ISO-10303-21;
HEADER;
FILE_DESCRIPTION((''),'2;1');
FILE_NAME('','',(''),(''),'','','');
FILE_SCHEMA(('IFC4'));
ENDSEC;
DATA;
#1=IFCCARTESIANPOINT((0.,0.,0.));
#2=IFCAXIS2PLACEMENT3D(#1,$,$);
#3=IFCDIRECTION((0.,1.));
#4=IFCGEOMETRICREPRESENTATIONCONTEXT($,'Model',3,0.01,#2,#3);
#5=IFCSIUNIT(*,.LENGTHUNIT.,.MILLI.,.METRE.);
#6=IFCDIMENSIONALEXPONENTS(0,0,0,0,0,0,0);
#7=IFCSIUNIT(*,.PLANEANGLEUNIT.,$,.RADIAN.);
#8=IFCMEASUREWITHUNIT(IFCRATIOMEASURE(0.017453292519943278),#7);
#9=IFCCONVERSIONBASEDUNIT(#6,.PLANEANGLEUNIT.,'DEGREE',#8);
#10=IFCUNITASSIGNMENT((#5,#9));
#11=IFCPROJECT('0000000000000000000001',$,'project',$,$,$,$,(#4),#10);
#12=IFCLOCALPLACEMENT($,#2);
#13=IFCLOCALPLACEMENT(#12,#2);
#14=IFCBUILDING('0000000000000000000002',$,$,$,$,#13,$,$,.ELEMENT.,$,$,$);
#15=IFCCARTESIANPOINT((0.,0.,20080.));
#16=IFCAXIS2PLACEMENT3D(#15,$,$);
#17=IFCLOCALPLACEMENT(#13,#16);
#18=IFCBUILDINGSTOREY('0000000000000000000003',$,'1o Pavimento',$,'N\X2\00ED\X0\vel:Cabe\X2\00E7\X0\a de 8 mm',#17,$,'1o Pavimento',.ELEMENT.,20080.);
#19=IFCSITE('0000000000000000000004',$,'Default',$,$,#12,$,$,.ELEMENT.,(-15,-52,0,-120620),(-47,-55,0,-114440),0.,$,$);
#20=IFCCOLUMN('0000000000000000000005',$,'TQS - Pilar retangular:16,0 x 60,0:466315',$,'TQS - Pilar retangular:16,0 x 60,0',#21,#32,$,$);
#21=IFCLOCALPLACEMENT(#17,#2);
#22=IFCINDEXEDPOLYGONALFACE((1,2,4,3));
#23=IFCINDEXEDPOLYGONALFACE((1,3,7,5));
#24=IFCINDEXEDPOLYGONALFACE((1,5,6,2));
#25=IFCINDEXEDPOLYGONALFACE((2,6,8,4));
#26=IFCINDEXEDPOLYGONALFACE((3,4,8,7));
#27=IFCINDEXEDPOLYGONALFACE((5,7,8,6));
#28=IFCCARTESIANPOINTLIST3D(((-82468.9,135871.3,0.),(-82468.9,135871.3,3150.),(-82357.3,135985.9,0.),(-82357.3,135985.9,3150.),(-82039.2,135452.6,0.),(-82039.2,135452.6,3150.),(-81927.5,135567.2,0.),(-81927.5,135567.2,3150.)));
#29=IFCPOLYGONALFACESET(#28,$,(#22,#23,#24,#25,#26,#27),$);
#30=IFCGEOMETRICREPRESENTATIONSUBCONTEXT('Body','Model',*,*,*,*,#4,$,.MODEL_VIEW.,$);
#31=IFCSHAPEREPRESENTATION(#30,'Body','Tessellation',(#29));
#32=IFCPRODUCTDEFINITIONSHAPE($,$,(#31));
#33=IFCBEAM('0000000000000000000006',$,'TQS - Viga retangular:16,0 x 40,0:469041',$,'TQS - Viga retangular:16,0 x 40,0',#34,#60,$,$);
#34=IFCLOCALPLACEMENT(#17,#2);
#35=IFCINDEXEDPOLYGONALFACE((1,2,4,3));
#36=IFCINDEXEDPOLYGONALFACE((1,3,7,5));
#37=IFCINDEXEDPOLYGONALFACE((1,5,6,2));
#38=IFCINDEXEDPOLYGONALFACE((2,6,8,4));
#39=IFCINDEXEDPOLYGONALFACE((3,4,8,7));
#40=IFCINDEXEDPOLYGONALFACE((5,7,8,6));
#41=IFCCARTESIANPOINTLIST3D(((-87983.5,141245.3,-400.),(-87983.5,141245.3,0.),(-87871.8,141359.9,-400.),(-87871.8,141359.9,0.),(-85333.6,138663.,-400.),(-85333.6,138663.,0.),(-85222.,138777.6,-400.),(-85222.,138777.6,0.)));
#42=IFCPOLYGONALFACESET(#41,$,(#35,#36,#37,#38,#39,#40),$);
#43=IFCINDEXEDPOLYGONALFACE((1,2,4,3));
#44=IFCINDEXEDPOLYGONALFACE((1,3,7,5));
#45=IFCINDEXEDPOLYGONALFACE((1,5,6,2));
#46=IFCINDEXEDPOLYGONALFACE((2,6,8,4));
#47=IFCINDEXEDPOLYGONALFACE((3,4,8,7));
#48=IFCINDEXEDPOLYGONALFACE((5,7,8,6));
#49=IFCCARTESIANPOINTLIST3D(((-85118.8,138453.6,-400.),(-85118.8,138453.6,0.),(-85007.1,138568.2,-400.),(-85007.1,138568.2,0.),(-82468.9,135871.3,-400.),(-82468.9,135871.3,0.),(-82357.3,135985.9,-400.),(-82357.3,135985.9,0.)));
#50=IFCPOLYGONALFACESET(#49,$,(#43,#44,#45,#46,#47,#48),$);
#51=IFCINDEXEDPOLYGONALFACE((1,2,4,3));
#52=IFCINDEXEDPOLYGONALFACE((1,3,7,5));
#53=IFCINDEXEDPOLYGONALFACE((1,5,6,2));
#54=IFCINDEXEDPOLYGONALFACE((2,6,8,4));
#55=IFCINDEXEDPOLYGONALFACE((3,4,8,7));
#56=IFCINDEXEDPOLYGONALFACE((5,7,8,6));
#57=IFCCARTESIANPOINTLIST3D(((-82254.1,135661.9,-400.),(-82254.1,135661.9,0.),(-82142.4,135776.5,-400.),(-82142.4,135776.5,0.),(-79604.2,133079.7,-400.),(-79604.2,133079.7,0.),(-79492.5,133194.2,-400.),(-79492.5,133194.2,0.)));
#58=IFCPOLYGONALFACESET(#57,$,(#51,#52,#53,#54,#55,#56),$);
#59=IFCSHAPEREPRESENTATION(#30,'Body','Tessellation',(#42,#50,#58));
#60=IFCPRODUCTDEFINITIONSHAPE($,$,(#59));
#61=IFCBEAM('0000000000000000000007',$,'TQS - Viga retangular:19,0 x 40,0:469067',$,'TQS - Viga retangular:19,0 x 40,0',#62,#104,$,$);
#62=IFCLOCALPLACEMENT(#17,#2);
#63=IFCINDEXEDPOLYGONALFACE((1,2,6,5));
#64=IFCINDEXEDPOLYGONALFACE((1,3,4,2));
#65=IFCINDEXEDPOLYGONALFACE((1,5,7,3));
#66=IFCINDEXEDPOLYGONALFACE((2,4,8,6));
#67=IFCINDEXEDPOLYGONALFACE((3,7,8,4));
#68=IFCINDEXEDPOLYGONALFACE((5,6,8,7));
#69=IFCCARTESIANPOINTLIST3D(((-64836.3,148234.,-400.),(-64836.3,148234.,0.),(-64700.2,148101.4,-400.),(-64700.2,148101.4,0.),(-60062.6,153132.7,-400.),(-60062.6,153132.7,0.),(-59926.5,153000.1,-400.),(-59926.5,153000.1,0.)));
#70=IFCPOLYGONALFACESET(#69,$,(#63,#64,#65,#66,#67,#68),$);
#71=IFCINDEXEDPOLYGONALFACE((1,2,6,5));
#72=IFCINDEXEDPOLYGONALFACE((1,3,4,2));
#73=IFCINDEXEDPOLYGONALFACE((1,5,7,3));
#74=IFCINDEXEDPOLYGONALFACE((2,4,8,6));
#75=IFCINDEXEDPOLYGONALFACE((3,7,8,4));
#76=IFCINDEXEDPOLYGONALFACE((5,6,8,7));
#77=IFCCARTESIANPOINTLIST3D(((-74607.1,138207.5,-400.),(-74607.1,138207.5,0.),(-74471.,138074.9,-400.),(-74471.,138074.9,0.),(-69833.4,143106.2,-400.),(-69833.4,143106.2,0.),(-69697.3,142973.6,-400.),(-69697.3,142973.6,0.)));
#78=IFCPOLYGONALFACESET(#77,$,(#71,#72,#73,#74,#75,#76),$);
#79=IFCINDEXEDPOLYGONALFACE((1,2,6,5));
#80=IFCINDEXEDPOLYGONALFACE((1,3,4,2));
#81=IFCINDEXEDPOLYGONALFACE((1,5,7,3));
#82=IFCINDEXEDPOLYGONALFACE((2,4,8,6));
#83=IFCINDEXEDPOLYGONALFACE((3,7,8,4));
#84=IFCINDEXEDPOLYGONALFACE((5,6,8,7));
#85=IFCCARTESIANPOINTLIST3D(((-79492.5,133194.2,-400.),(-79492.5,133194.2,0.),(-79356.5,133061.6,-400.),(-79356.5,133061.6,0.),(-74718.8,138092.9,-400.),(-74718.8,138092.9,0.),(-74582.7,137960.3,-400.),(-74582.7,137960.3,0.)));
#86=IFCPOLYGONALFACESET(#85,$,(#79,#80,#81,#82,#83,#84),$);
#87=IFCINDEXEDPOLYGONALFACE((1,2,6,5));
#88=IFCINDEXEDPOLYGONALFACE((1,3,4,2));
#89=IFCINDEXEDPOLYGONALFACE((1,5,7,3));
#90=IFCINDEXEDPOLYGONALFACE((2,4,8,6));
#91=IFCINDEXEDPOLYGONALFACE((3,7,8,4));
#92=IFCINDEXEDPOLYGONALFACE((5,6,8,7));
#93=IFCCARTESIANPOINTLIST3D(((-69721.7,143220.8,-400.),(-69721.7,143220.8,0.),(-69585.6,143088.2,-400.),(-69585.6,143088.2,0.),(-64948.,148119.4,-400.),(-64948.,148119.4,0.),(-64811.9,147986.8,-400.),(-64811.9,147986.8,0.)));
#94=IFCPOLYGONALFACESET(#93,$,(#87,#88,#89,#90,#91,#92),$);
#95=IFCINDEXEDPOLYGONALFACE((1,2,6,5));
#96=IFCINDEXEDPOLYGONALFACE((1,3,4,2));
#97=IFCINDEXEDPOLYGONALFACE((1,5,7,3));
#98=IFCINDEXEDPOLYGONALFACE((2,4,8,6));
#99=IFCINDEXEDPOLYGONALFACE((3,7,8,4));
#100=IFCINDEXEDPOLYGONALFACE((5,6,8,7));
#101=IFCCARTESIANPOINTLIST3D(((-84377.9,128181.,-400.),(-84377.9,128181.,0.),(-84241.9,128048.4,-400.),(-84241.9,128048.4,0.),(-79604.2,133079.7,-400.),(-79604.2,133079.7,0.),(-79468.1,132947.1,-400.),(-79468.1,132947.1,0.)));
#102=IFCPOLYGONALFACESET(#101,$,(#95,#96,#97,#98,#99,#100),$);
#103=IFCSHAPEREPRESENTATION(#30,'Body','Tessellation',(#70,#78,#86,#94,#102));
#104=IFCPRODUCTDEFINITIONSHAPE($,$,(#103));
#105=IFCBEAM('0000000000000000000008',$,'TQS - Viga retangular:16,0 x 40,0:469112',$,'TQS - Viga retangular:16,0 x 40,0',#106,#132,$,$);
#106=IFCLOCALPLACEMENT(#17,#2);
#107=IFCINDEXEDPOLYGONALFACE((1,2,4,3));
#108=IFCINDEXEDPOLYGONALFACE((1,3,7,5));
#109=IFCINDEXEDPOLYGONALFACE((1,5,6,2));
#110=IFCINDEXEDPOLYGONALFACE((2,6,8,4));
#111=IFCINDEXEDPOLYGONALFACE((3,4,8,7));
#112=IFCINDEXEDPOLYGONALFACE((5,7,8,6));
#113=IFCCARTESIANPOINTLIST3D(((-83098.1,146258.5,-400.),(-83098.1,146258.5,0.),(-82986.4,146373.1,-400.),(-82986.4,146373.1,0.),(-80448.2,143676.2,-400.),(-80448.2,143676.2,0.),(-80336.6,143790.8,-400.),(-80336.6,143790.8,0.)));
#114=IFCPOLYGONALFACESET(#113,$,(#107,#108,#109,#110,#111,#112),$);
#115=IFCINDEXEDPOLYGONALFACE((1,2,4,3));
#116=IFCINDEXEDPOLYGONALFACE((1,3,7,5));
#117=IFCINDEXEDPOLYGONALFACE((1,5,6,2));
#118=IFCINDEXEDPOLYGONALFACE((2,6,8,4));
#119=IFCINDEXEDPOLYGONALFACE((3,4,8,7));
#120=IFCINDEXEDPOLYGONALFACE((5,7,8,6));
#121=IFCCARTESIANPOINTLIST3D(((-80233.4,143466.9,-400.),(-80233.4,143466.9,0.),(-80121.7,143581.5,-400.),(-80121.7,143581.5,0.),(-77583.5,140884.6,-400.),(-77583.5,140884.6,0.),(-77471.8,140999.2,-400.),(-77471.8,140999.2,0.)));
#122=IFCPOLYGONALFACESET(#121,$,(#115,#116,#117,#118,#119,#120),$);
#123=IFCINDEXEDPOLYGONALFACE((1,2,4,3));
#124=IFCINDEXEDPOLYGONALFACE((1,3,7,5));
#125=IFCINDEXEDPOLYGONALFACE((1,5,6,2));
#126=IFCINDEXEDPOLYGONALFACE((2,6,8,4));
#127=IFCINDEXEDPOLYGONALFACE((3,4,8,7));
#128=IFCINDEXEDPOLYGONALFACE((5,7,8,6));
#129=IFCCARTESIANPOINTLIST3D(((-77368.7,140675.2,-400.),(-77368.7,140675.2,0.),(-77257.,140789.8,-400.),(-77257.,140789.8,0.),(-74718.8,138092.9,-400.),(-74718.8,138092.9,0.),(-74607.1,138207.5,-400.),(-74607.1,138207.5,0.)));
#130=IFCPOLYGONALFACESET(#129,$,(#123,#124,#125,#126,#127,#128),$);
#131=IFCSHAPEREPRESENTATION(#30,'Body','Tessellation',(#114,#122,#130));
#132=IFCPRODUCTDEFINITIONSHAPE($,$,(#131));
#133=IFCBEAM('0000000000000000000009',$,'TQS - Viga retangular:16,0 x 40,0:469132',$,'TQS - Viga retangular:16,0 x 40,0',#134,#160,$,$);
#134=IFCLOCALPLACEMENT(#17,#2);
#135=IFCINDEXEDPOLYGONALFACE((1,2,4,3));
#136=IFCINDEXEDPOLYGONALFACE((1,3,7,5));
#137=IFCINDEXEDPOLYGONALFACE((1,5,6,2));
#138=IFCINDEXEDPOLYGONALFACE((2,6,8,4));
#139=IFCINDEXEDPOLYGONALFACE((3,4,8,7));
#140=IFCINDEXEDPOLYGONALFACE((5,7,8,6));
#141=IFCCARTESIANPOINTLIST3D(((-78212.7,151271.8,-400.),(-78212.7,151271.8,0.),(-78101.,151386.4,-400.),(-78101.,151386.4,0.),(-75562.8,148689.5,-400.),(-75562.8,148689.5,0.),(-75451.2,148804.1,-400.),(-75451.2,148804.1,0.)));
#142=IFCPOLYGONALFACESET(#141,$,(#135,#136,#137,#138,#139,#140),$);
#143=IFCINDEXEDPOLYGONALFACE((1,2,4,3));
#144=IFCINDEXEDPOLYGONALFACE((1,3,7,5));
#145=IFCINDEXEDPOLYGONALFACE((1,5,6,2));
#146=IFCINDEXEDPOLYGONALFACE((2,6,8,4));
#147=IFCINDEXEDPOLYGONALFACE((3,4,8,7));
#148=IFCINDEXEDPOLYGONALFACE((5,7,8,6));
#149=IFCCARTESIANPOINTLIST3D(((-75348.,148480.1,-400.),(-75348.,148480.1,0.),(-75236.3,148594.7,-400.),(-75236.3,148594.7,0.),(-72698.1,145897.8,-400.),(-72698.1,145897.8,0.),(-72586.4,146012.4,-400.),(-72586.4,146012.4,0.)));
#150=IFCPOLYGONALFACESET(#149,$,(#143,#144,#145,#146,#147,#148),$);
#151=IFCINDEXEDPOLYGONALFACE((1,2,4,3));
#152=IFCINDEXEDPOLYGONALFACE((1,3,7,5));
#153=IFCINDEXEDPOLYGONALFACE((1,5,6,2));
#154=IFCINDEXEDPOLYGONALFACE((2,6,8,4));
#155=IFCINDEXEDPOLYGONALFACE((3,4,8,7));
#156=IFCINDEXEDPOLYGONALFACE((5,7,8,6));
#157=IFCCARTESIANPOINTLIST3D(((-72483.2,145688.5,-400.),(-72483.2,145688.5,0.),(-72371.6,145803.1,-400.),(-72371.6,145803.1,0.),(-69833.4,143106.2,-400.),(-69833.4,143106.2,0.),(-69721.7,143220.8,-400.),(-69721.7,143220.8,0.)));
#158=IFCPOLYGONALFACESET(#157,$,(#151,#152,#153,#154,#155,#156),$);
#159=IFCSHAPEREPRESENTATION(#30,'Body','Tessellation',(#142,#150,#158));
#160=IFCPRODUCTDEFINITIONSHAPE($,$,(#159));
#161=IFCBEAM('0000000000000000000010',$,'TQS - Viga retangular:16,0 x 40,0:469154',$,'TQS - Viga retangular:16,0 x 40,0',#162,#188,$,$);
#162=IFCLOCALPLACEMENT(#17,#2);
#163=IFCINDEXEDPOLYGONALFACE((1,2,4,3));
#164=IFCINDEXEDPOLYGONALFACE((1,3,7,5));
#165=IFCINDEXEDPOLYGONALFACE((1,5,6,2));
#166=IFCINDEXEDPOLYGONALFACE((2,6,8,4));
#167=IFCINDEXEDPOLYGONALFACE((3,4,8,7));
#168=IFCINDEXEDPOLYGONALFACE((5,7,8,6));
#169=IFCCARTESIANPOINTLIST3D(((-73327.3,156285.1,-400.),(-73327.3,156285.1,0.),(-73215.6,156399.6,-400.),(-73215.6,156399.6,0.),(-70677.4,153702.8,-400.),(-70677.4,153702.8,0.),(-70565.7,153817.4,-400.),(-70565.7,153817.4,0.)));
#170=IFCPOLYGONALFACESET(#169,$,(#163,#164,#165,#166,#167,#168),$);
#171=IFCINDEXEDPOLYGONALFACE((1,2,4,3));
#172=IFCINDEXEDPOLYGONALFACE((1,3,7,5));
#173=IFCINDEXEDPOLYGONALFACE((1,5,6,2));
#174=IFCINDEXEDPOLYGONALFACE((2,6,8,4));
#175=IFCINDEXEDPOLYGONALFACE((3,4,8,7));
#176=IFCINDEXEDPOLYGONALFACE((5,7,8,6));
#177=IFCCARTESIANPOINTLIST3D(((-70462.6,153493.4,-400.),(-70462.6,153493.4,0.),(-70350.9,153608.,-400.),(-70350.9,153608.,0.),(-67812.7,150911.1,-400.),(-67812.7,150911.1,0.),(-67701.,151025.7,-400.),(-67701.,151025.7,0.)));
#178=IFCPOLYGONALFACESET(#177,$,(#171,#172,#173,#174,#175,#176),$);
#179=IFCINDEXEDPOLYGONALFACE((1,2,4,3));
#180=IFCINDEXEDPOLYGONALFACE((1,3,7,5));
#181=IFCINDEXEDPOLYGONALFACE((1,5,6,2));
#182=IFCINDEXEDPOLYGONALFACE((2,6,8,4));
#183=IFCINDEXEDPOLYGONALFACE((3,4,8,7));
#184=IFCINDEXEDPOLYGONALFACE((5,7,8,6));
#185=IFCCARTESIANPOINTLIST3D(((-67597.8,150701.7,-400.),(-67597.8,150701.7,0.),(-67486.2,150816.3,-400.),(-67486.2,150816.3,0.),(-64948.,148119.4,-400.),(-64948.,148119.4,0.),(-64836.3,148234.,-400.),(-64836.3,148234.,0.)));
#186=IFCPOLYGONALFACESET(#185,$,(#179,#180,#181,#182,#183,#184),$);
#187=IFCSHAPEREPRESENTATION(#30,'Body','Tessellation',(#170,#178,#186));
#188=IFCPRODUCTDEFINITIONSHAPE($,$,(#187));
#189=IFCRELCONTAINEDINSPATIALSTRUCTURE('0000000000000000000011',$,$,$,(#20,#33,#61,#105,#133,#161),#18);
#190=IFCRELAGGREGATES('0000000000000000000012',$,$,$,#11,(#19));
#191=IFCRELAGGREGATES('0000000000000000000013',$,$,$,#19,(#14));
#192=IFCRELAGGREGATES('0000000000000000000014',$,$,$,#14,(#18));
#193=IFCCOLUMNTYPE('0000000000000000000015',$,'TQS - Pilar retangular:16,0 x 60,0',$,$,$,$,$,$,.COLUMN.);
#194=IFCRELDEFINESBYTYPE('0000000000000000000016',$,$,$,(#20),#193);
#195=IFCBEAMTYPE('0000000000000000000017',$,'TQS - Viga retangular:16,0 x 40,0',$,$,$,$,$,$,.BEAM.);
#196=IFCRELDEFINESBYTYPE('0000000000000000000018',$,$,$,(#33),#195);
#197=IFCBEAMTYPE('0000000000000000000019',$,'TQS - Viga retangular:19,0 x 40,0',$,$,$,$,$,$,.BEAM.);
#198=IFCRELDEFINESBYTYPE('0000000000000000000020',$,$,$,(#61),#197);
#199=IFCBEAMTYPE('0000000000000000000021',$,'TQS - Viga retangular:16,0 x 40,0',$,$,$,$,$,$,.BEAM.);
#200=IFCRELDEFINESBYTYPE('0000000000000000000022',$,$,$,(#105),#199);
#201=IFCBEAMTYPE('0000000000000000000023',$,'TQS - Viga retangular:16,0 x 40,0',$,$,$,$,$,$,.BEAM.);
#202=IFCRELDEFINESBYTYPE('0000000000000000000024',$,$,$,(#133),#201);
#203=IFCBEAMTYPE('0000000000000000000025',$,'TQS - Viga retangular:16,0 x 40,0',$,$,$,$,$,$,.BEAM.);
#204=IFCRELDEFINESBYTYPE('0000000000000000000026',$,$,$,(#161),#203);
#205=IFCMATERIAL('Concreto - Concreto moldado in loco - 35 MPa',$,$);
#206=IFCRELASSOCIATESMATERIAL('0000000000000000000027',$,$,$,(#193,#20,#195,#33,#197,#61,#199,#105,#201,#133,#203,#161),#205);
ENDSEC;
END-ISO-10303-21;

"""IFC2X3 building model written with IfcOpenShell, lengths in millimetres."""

from ifc_helpers import new_model, entity, si_unit, converted_unit, direction, frame, frame_2d, origin, place, context, subcontext, project, spatial, rectangle, extrude, source, transform, mapped, material, type_object, type_shapes, element, save


model = new_model("IFC2X3")

# Units and contexts
model_context = context("Model", 3, precision=0.01, world=origin(), true_north=direction((0.0, 1.0)))
body_context = subcontext(model_context, "Body", "Model", "MODEL_VIEW")
ifc_project = project(units=[si_unit("LENGTHUNIT", "METRE", prefix="MILLI"), converted_unit("PLANEANGLEUNIT", "DEGREE", entity("IfcRatioMeasure", 0.017453292519943278), si_unit("PLANEANGLEUNIT", "RADIAN"), dimensions=[0, 0, 0, 0, 0, 0, 0])], contexts=[model_context])

# Site, building, storey
site_placement = place(None, origin())
site = spatial("IfcSite", under=ifc_project, at=site_placement, Name="Default", CompositionType="ELEMENT", RefLatitude=(-15, -52, 0, -120620), RefLongitude=(-47, -55, 0, -114440), RefElevation=0.0)
building_placement = place(site_placement, origin())
building = spatial("IfcBuilding", under=site, at=building_placement, CompositionType="ELEMENT")
storey_placement = place(building_placement, frame((0.0, 0.0, 20080.0)))
storey = spatial("IfcBuildingStorey", under=building, at=storey_placement, Name="1o Pavimento", ObjectType="Nível:Cabeça de 8 mm", LongName="1o Pavimento", CompositionType="ELEMENT", Elevation=20080.0)

# Column
ifc_material = material(Name="Concreto - Concreto moldado in loco - 35 MPa")
column_type = type_object("IfcColumnType", Name="TQS - Pilar retangular:16,0 x 60,0", PredefinedType="COLUMN", material=ifc_material)
shared_shape_1 = source(origin(), body_context, "Body", "SweptSolid", [
    extrude(rectangle(XDim=600.0, YDim=160.0, at=frame_2d((0.0, 0.0), x_axis=(1.0, 0.0))), frame((-82198.2, 135719.2, 20080.0), z_axis=(0.0, 0.0, 1.0), x_axis=(-0.71618, 0.697915, 0.0)), (0.0, 0.0, 1.0), 3150.0),
])
type_shapes(column_type, [shared_shape_1])
column_placement = place(storey_placement, frame((0.0, 0.0, -20080.0)))
element("IfcColumn", 1, at=column_placement, inside=storey, type_object=column_type, material=ifc_material, Name="TQS - Pilar retangular:16,0 x 60,0:466315", ObjectType="TQS - Pilar retangular:16,0 x 60,0", context=body_context, shape_type="MappedRepresentation", body=[
    mapped(shared_shape_1, transform((0.0, 0.0, 0.0), scale=1.0)),
])

# Beams
beam_type_1 = type_object("IfcBeamType", Name="TQS - Viga retangular:16,0 x 40,0", PredefinedType="BEAM", material=ifc_material)
shared_shape_2 = source(origin(), body_context, "Body", "SweptSolid", [
    extrude(rectangle(XDim=400.0, YDim=160.0, at=frame_2d((0.0, 0.0), x_axis=(1.0, 0.0))), frame((-85277.8, 138720.3, 19880.0), z_axis=(-0.71618, 0.697915, 0.0), x_axis=(0.0, 0.0, 1.0)), (0.0, 0.0, 1.0), 3700.0),
    extrude(rectangle(XDim=400.0, YDim=160.0, at=frame_2d((0.0, 0.0), x_axis=(1.0, 0.0))), frame((-82413.1, 135928.6, 19880.0), z_axis=(-0.71618, 0.697915, 0.0), x_axis=(0.0, 0.0, 1.0)), (0.0, 0.0, 1.0), 3700.0),
    extrude(rectangle(XDim=400.0, YDim=160.0, at=frame_2d((0.0, 0.0), x_axis=(1.0, 0.0))), frame((-79548.4, 133137.0, 19880.0), z_axis=(-0.71618, 0.697915, 0.0), x_axis=(0.0, 0.0, 1.0)), (0.0, 0.0, 1.0), 3700.0),
])
type_shapes(beam_type_1, [shared_shape_2])
beam_1_placement = place(storey_placement, frame((0.0, 0.0, -20080.0)))
element("IfcBeam", 2, at=beam_1_placement, inside=storey, type_object=beam_type_1, material=ifc_material, Name="TQS - Viga retangular:16,0 x 40,0:469041", ObjectType="TQS - Viga retangular:16,0 x 40,0", context=body_context, shape_type="MappedRepresentation", body=[
    mapped(shared_shape_2, transform((0.0, 0.0, 0.0), scale=1.0)),
])
beam_type_2 = type_object("IfcBeamType", Name="TQS - Viga retangular:19,0 x 40,0", PredefinedType="BEAM", material=ifc_material)
shared_shape_3 = source(origin(), body_context, "Body", "SweptSolid", [
    extrude(rectangle(XDim=400.0, YDim=190.0, at=frame_2d((0.0, 0.0), x_axis=(1.0, 0.0))), frame((-64768.3, 148167.7, 19880.0), z_axis=(0.697915, 0.71618, 0.0), x_axis=(0.0, 0.0, 1.0)), (0.0, 0.0, 1.0), 6840.0),
    extrude(rectangle(XDim=400.0, YDim=190.0, at=frame_2d((0.0, 0.0), x_axis=(1.0, 0.0))), frame((-74539.1, 138141.2, 19880.0), z_axis=(0.697915, 0.71618, 0.0), x_axis=(0.0, 0.0, 1.0)), (0.0, 0.0, 1.0), 6840.0),
    extrude(rectangle(XDim=400.0, YDim=190.0, at=frame_2d((0.0, 0.0), x_axis=(1.0, 0.0))), frame((-79424.5, 133127.9, 19880.0), z_axis=(0.697915, 0.71618, 0.0), x_axis=(0.0, 0.0, 1.0)), (0.0, 0.0, 1.0), 6840.0),
    extrude(rectangle(XDim=400.0, YDim=190.0, at=frame_2d((0.0, 0.0), x_axis=(1.0, 0.0))), frame((-69653.7, 143154.5, 19880.0), z_axis=(0.697915, 0.71618, 0.0), x_axis=(0.0, 0.0, 1.0)), (0.0, 0.0, 1.0), 6840.0),
    extrude(rectangle(XDim=400.0, YDim=190.0, at=frame_2d((0.0, 0.0), x_axis=(1.0, 0.0))), frame((-84309.9, 128114.7, 19880.0), z_axis=(0.697915, 0.71618, 0.0), x_axis=(0.0, 0.0, 1.0)), (0.0, 0.0, 1.0), 6840.0),
])
type_shapes(beam_type_2, [shared_shape_3])
beam_2_placement = place(storey_placement, frame((0.0, 0.0, -20080.0)))
element("IfcBeam", 3, at=beam_2_placement, inside=storey, type_object=beam_type_2, material=ifc_material, Name="TQS - Viga retangular:19,0 x 40,0:469067", ObjectType="TQS - Viga retangular:19,0 x 40,0", context=body_context, shape_type="MappedRepresentation", body=[
    mapped(shared_shape_3, transform((0.0, 0.0, 0.0), scale=1.0)),
])
beam_type_3 = type_object("IfcBeamType", Name="TQS - Viga retangular:16,0 x 40,0", PredefinedType="BEAM", material=ifc_material)
shared_shape_4 = source(origin(), body_context, "Body", "SweptSolid", [
    extrude(rectangle(XDim=400.0, YDim=160.0, at=frame_2d((0.0, 0.0), x_axis=(1.0, 0.0))), frame((-80392.4, 143733.5, 19880.0), z_axis=(-0.71618, 0.697915, 0.0), x_axis=(0.0, 0.0, 1.0)), (0.0, 0.0, 1.0), 3700.0),
    extrude(rectangle(XDim=400.0, YDim=160.0, at=frame_2d((0.0, 0.0), x_axis=(1.0, 0.0))), frame((-77527.7, 140941.9, 19880.0), z_axis=(-0.71618, 0.697915, 0.0), x_axis=(0.0, 0.0, 1.0)), (0.0, 0.0, 1.0), 3700.0),
    extrude(rectangle(XDim=400.0, YDim=160.0, at=frame_2d((0.0, 0.0), x_axis=(1.0, 0.0))), frame((-74663.0, 138150.2, 19880.0), z_axis=(-0.71618, 0.697915, 0.0), x_axis=(0.0, 0.0, 1.0)), (0.0, 0.0, 1.0), 3700.0),
])
type_shapes(beam_type_3, [shared_shape_4])
beam_3_placement = place(storey_placement, frame((0.0, 0.0, -20080.0)))
element("IfcBeam", 4, at=beam_3_placement, inside=storey, type_object=beam_type_3, material=ifc_material, Name="TQS - Viga retangular:16,0 x 40,0:469112", ObjectType="TQS - Viga retangular:16,0 x 40,0", context=body_context, shape_type="MappedRepresentation", body=[
    mapped(shared_shape_4, transform((0.0, 0.0, 0.0), scale=1.0)),
])
beam_type_4 = type_object("IfcBeamType", Name="TQS - Viga retangular:16,0 x 40,0", PredefinedType="BEAM", material=ifc_material)
shared_shape_5 = source(origin(), body_context, "Body", "SweptSolid", [
    extrude(rectangle(XDim=400.0, YDim=160.0, at=frame_2d((0.0, 0.0), x_axis=(1.0, 0.0))), frame((-75507.0, 148746.8, 19880.0), z_axis=(-0.71618, 0.697915, 0.0), x_axis=(0.0, 0.0, 1.0)), (0.0, 0.0, 1.0), 3700.0),
    extrude(rectangle(XDim=400.0, YDim=160.0, at=frame_2d((0.0, 0.0), x_axis=(1.0, 0.0))), frame((-72642.3, 145955.1, 19880.0), z_axis=(-0.71618, 0.697915, 0.0), x_axis=(0.0, 0.0, 1.0)), (0.0, 0.0, 1.0), 3700.0),
    extrude(rectangle(XDim=400.0, YDim=160.0, at=frame_2d((0.0, 0.0), x_axis=(1.0, 0.0))), frame((-69777.5, 143163.5, 19880.0), z_axis=(-0.71618, 0.697915, 0.0), x_axis=(0.0, 0.0, 1.0)), (0.0, 0.0, 1.0), 3700.0),
])
type_shapes(beam_type_4, [shared_shape_5])
beam_4_placement = place(storey_placement, frame((0.0, 0.0, -20080.0)))
element("IfcBeam", 5, at=beam_4_placement, inside=storey, type_object=beam_type_4, material=ifc_material, Name="TQS - Viga retangular:16,0 x 40,0:469132", ObjectType="TQS - Viga retangular:16,0 x 40,0", context=body_context, shape_type="MappedRepresentation", body=[
    mapped(shared_shape_5, transform((0.0, 0.0, 0.0), scale=1.0)),
])
beam_type_5 = type_object("IfcBeamType", Name="TQS - Viga retangular:16,0 x 40,0", PredefinedType="BEAM", material=ifc_material)
shared_shape_6 = source(origin(), body_context, "Body", "SweptSolid", [
    extrude(rectangle(XDim=400.0, YDim=160.0, at=frame_2d((0.0, 0.0), x_axis=(1.0, 0.0))), frame((-70621.6, 153760.1, 19880.0), z_axis=(-0.71618, 0.697915, 0.0), x_axis=(0.0, 0.0, 1.0)), (0.0, 0.0, 1.0), 3700.0),
    extrude(rectangle(XDim=400.0, YDim=160.0, at=frame_2d((0.0, 0.0), x_axis=(1.0, 0.0))), frame((-67756.9, 150968.4, 19880.0), z_axis=(-0.71618, 0.697915, 0.0), x_axis=(0.0, 0.0, 1.0)), (0.0, 0.0, 1.0), 3700.0),
    extrude(rectangle(XDim=400.0, YDim=160.0, at=frame_2d((0.0, 0.0), x_axis=(1.0, 0.0))), frame((-64892.1, 148176.7, 19880.0), z_axis=(-0.71618, 0.697915, 0.0), x_axis=(0.0, 0.0, 1.0)), (0.0, 0.0, 1.0), 3700.0),
])
type_shapes(beam_type_5, [shared_shape_6])
beam_5_placement = place(storey_placement, frame((0.0, 0.0, -20080.0)))
element("IfcBeam", 6, at=beam_5_placement, inside=storey, type_object=beam_type_5, material=ifc_material, Name="TQS - Viga retangular:16,0 x 40,0:469154", ObjectType="TQS - Viga retangular:16,0 x 40,0", context=body_context, shape_type="MappedRepresentation", body=[
    mapped(shared_shape_6, transform((0.0, 0.0, 0.0), scale=1.0)),
])

save(model, "model.ifc")
